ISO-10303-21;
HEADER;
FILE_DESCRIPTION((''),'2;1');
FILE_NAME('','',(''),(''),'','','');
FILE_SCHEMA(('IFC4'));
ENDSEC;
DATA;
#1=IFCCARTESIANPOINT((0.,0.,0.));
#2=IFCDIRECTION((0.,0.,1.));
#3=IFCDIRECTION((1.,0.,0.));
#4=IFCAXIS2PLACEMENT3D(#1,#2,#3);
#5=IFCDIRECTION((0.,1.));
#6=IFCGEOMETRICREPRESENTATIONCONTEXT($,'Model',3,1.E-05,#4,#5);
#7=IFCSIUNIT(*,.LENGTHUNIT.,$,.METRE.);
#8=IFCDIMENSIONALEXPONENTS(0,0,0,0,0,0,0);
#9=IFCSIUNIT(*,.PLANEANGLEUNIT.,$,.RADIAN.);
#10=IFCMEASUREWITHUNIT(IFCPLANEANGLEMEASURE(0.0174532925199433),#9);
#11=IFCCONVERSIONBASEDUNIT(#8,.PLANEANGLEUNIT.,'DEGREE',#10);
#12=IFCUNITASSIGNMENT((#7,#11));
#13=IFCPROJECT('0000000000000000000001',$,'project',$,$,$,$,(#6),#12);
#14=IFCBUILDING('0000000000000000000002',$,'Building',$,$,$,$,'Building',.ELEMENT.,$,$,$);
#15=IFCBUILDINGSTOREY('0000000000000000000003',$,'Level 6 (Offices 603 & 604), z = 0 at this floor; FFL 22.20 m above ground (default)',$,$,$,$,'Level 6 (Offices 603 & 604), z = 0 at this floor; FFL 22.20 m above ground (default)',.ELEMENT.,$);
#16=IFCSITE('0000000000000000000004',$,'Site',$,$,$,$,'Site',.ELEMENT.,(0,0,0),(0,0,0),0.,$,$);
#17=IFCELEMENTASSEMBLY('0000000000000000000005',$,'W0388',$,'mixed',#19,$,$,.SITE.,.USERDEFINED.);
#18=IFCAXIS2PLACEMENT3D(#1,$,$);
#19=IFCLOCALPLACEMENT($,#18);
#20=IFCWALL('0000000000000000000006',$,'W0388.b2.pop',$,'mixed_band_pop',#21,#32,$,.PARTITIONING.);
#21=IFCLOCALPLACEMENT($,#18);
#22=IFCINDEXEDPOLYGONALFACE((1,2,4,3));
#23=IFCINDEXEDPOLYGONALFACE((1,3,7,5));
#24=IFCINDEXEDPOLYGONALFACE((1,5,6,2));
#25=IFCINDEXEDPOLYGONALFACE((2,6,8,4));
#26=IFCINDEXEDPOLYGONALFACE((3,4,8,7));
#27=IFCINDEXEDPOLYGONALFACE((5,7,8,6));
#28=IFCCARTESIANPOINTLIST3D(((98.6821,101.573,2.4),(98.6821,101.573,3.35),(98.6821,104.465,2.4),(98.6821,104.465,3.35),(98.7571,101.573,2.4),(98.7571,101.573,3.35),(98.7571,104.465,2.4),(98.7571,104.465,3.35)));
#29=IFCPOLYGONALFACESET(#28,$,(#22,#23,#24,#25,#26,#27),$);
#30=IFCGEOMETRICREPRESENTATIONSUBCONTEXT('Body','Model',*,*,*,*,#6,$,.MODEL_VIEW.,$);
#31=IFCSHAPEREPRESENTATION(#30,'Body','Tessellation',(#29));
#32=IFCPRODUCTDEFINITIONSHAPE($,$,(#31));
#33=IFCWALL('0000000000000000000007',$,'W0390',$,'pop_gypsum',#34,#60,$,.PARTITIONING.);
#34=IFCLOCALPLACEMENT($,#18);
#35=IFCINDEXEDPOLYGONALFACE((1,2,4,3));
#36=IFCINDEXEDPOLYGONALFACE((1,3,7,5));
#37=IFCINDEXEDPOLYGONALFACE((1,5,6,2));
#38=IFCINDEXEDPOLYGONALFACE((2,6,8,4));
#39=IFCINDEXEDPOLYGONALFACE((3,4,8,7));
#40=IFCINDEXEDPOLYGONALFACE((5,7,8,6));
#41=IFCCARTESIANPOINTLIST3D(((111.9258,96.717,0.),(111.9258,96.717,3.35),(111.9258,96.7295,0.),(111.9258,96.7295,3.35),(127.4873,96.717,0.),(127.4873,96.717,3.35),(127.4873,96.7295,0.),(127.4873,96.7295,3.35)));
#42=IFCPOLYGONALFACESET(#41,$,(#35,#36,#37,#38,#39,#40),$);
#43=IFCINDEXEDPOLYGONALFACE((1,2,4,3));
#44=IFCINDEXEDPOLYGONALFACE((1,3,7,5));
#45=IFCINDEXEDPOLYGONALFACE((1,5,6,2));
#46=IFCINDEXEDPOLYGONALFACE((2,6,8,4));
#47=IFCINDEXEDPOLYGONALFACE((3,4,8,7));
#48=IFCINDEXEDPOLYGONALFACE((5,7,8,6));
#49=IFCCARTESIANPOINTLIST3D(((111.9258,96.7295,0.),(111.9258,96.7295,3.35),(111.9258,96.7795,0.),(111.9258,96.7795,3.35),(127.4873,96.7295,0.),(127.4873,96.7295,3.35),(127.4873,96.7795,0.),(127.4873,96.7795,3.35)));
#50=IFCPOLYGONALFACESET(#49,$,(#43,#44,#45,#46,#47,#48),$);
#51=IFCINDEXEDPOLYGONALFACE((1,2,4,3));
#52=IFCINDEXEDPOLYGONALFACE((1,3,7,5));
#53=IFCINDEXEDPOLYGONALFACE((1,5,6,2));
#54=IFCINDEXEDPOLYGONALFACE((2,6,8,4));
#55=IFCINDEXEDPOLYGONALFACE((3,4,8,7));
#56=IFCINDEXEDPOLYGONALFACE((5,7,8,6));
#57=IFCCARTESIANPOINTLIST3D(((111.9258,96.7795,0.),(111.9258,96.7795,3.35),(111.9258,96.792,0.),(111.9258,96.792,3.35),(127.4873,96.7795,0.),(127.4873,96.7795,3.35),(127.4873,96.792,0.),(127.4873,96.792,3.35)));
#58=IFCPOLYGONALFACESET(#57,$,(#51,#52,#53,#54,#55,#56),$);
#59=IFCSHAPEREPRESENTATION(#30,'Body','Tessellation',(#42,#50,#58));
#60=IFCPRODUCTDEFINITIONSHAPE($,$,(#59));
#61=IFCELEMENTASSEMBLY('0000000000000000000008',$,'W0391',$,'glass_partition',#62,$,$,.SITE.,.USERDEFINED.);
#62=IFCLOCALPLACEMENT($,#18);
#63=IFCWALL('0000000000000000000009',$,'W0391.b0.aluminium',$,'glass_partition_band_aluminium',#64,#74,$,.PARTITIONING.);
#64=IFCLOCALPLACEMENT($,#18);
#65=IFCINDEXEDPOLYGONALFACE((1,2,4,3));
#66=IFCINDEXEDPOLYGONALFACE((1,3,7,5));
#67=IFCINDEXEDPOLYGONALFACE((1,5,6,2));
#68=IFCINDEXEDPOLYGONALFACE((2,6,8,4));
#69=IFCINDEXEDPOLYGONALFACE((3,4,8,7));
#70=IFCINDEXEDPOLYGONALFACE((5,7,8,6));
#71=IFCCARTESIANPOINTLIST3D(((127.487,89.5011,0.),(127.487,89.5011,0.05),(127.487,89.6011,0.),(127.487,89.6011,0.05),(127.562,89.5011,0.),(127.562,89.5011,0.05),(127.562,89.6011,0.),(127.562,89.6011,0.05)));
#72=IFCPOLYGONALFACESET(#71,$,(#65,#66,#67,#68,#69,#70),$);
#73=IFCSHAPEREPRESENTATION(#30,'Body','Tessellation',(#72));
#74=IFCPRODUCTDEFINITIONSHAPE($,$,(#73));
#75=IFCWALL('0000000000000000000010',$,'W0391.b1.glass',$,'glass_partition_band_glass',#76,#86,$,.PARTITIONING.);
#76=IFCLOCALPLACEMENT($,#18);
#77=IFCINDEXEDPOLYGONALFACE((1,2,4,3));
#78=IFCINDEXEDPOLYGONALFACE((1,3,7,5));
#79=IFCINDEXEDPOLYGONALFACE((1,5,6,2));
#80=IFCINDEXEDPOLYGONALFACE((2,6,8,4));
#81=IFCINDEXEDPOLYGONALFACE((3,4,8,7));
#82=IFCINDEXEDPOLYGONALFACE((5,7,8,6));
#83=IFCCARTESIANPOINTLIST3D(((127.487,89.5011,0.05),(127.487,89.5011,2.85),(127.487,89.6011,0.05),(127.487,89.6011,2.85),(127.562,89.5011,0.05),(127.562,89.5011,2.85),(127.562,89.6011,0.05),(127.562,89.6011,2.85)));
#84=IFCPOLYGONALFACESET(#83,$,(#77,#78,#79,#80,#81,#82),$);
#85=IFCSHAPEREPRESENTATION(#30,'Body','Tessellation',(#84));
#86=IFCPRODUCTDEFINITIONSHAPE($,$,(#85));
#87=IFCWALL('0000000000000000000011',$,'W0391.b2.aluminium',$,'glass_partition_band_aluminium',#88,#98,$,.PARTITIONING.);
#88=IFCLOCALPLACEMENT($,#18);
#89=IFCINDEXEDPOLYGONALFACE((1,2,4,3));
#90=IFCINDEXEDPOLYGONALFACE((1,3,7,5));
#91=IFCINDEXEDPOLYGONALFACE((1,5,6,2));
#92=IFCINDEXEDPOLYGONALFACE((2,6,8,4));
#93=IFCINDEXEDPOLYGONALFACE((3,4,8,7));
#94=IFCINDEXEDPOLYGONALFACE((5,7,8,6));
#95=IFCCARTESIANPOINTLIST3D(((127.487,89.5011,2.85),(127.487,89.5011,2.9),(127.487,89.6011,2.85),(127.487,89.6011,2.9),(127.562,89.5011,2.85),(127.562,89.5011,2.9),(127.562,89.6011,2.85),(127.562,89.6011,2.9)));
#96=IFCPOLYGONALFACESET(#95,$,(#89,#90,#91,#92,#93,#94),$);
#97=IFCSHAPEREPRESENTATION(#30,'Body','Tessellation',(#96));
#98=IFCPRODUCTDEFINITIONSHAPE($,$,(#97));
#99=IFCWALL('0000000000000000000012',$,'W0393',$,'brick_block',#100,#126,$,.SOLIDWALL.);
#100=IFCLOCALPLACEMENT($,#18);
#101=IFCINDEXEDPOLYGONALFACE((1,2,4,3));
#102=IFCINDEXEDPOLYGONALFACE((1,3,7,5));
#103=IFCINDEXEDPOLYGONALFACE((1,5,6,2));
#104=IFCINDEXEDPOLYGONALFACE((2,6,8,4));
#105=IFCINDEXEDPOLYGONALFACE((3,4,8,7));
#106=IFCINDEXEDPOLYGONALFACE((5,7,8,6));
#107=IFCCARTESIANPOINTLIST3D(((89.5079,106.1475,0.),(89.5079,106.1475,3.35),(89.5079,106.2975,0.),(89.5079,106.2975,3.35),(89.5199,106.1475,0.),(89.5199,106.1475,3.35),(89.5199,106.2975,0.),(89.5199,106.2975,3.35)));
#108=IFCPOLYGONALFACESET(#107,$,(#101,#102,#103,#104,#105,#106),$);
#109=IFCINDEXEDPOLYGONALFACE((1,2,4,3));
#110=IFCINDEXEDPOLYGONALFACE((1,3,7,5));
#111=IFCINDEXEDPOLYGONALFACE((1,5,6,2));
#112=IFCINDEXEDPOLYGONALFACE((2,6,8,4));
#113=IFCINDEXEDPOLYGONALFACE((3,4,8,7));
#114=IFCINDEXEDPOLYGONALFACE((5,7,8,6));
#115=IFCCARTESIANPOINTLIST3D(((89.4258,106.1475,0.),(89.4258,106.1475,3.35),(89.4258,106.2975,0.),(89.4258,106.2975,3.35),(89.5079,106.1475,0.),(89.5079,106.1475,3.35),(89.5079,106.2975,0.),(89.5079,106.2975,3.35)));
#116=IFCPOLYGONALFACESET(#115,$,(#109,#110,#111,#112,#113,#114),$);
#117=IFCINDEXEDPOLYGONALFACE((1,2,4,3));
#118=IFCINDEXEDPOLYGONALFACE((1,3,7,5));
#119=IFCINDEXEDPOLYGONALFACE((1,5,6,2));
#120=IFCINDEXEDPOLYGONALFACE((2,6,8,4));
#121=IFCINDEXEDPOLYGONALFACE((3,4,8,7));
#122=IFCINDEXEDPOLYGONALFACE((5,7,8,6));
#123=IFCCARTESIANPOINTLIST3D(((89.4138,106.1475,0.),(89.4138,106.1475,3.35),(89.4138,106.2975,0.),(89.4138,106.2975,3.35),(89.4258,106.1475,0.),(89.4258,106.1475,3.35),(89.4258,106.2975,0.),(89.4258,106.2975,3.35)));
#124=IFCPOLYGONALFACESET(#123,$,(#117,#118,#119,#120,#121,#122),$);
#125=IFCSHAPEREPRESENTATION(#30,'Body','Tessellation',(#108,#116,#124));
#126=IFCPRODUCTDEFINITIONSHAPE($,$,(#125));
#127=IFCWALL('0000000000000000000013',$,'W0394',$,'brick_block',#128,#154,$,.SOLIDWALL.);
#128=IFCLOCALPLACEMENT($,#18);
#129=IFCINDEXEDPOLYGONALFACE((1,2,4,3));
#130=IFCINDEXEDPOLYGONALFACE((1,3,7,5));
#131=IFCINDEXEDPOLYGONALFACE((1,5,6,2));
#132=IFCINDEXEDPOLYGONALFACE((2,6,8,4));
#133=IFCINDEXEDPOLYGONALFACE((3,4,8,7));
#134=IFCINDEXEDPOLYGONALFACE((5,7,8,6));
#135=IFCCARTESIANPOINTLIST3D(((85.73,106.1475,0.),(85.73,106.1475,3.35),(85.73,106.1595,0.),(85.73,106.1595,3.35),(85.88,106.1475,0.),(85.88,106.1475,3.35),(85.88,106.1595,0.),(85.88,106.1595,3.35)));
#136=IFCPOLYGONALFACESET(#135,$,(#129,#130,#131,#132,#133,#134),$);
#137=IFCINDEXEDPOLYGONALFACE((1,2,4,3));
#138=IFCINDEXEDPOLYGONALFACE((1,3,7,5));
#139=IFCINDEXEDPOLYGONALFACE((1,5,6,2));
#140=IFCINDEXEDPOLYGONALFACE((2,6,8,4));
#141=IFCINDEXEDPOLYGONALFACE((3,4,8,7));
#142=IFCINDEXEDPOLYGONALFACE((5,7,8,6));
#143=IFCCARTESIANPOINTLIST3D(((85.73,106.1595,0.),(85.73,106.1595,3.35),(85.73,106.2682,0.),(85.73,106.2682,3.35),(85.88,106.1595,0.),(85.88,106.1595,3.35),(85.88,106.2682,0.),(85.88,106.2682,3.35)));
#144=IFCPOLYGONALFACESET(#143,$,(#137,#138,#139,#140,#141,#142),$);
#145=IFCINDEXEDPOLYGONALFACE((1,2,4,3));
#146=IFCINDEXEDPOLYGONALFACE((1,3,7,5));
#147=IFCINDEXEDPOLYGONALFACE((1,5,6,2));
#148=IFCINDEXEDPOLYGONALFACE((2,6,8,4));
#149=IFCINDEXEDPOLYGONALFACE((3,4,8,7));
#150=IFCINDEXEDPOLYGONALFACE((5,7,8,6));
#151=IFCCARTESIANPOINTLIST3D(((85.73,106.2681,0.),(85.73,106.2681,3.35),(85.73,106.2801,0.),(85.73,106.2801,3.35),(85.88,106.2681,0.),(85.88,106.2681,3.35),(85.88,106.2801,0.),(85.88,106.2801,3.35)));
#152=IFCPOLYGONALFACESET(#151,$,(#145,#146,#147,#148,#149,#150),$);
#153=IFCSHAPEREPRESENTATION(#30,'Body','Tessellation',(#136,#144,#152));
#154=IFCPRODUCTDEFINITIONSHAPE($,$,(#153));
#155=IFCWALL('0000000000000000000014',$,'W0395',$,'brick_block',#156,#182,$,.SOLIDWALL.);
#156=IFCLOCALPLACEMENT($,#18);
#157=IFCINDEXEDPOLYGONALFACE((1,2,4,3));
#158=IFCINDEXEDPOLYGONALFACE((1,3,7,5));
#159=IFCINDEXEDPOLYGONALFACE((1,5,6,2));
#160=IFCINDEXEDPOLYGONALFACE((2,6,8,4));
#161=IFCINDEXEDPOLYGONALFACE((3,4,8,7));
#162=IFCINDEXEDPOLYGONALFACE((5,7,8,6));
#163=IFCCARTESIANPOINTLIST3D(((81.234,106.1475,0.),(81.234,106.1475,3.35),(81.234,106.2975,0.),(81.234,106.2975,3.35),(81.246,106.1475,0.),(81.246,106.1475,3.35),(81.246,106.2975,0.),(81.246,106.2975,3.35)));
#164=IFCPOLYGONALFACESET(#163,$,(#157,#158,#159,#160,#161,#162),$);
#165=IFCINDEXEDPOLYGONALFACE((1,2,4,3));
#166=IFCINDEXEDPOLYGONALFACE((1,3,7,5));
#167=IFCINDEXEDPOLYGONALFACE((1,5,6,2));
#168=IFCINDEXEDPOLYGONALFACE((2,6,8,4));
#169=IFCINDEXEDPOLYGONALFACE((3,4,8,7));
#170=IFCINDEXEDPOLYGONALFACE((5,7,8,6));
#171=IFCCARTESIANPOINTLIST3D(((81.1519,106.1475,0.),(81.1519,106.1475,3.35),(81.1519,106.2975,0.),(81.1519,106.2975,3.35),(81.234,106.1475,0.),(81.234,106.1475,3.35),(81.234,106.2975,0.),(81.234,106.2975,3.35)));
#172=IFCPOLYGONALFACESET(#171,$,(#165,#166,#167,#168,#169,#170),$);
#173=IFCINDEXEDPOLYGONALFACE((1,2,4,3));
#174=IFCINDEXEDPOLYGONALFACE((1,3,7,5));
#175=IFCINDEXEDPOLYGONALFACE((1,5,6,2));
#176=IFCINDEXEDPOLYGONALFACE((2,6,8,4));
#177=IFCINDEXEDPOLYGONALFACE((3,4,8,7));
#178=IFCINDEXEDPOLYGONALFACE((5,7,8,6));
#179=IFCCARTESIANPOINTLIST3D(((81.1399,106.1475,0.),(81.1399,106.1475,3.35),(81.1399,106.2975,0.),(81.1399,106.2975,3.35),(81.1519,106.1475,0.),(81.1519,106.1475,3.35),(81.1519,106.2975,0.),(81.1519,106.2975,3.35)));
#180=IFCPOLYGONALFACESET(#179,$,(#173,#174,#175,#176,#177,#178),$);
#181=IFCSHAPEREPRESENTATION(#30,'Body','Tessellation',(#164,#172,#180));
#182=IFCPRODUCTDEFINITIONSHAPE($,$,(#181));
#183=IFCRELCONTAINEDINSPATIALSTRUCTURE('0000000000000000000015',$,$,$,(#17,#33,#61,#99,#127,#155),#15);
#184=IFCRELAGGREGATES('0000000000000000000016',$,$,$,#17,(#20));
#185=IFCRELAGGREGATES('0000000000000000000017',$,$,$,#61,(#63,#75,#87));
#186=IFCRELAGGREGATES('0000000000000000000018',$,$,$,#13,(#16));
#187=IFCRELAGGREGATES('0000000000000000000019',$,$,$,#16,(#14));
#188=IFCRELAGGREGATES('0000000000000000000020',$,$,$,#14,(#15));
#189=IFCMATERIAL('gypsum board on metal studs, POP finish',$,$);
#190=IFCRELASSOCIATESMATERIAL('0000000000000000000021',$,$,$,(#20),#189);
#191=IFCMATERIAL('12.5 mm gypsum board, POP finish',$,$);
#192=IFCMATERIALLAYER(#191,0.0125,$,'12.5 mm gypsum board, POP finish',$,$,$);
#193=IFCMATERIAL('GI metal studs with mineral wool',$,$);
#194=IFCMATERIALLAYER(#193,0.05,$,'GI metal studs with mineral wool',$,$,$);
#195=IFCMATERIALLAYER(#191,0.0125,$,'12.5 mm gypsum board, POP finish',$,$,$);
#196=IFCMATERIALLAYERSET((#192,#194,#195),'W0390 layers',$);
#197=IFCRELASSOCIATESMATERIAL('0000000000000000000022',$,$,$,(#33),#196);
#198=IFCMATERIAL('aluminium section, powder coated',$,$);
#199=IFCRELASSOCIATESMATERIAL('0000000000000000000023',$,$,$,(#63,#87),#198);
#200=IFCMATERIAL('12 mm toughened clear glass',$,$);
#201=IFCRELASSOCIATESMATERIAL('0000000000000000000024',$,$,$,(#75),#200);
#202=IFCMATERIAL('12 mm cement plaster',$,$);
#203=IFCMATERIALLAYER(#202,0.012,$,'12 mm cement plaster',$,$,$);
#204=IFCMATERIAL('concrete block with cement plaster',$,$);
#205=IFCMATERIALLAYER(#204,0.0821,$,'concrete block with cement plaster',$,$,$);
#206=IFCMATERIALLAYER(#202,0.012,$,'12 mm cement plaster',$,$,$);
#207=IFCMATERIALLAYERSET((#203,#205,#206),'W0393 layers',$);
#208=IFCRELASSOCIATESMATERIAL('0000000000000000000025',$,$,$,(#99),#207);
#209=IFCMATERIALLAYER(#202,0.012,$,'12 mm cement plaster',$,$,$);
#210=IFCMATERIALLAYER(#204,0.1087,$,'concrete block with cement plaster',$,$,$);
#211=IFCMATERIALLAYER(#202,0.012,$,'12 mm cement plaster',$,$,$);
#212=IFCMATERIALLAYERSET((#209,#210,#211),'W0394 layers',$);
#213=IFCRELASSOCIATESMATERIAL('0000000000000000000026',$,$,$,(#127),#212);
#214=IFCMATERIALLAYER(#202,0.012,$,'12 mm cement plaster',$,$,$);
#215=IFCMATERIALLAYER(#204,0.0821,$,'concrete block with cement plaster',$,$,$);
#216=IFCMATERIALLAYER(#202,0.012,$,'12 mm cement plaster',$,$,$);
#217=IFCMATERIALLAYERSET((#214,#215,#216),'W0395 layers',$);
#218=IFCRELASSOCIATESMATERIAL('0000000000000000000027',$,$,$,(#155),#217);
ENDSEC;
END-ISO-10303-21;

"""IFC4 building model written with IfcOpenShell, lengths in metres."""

from ifc_helpers import new_model, entity, si_unit, converted_unit, direction, frame, frame_2d, origin_with_axes, place, context, subcontext, project, spatial, rectangle, extrude, material, layer, layer_set, layer_usage, element, aggregate, save


model = new_model("IFC4")

# Units and contexts
model_context = context("Model", 3, precision=1e-05, world=origin_with_axes(), true_north=direction((0.0, 1.0)))
body_context = subcontext(model_context, "Body", "Model", "MODEL_VIEW")
ifc_project = project(units=[si_unit("LENGTHUNIT", "METRE"), converted_unit("PLANEANGLEUNIT", "DEGREE", entity("IfcPlaneAngleMeasure", 0.0174532925199433), si_unit("PLANEANGLEUNIT", "RADIAN"), dimensions=[0, 0, 0, 0, 0, 0, 0])], contexts=[model_context])

# Site, building, storey
site = spatial("IfcSite", under=ifc_project, Name="Site", LongName="Site", CompositionType="ELEMENT", RefLatitude=(0, 0, 0), RefLongitude=(0, 0, 0), RefElevation=0.0)
building = spatial("IfcBuilding", under=site, Name="Building", LongName="Building", CompositionType="ELEMENT")
storey = spatial("IfcBuildingStorey", under=building, Name="Level 6 (Offices 603 & 604), z = 0 at this floor; FFL 22.20 m above ground (default)", LongName="Level 6 (Offices 603 & 604), z = 0 at this floor; FFL 22.20 m above ground (default)", CompositionType="ELEMENT")

# Element assembly, wall
assembly_1 = element("IfcElementAssembly", 1, inside=storey, Name="W0388", ObjectType="mixed", AssemblyPlace="SITE", PredefinedType="USERDEFINED")
ifc_material_1 = material(Name="gypsum board on metal studs, POP finish")
placement = place(None, origin_with_axes())
wall_1 = element("IfcWall", 2, at=placement, material=ifc_material_1, Name="W0388.b2.pop", ObjectType="mixed_band_pop", PredefinedType="PARTITIONING", context=body_context, shape_type="SweptSolid", body=[
    extrude(rectangle(XDim=2.892, YDim=0.075, at=frame_2d((0.0, 0.0), x_axis=(0.0, 1.0))), frame((98.7196, 103.019, 2.4), z_axis=(0.0, 0.0, 1.0), x_axis=(1.0, 0.0, 0.0)), (0.0, 0.0, 1.0), 0.95),
])
aggregate(assembly_1, [wall_1])

# Wall
ifc_material_2 = material(Name="12.5 mm gypsum board, POP finish")
ifc_layer_1 = layer(ifc_material_2, 0.0125, Name="12.5 mm gypsum board, POP finish")
ifc_material_3 = material(Name="GI metal studs with mineral wool")
ifc_layer_2 = layer(ifc_material_3, 0.05, Name="GI metal studs with mineral wool")
ifc_layer_3 = layer(ifc_material_2, 0.0125, Name="12.5 mm gypsum board, POP finish")
ifc_layer_set_1 = layer_set([ifc_layer_1, ifc_layer_2, ifc_layer_3], Name="W0390 layers")
ifc_layer_usage_1 = layer_usage(ifc_layer_set_1, "AXIS2", "POSITIVE", -0.0375)
element("IfcWall", 3, at=placement, inside=storey, material=ifc_layer_usage_1, Name="W0390", ObjectType="pop_gypsum", PredefinedType="PARTITIONING", context=body_context, shape_type="SweptSolid", body=[
    extrude(rectangle(XDim=15.5615, YDim=0.0125, at=frame_2d((0.0, 0.0), x_axis=(1.0, 0.0))), frame((119.7065, 96.7232, 0.0), z_axis=(0.0, 0.0, 1.0), x_axis=(1.0, 0.0, 0.0)), (0.0, 0.0, 1.0), 3.35),
    extrude(rectangle(XDim=15.5615, YDim=0.05, at=frame_2d((0.0, 0.0312), x_axis=(1.0, 0.0))), frame((119.7065, 96.7232, 0.0), z_axis=(0.0, 0.0, 1.0), x_axis=(1.0, 0.0, 0.0)), (0.0, 0.0, 1.0), 3.35),
    extrude(rectangle(XDim=15.5615, YDim=0.0125, at=frame_2d((0.0, 0.0625), x_axis=(1.0, 0.0))), frame((119.7065, 96.7232, 0.0), z_axis=(0.0, 0.0, 1.0), x_axis=(1.0, 0.0, 0.0)), (0.0, 0.0, 1.0), 3.35),
])

# Element assembly, walls
assembly_2 = element("IfcElementAssembly", 4, inside=storey, Name="W0391", ObjectType="glass_partition", AssemblyPlace="SITE", PredefinedType="USERDEFINED")
ifc_material_4 = material(Name="aluminium section, powder coated")
wall_2 = element("IfcWall", 5, at=placement, material=ifc_material_4, Name="W0391.b0.aluminium", ObjectType="glass_partition_band_aluminium", PredefinedType="PARTITIONING", context=body_context, shape_type="SweptSolid", body=[
    extrude(rectangle(XDim=0.1, YDim=0.075, at=frame_2d((0.0, 0.0), x_axis=(0.0, 1.0))), frame((127.5245, 89.5511, 0.0), z_axis=(0.0, 0.0, 1.0), x_axis=(1.0, 0.0, 0.0)), (0.0, 0.0, 1.0), 0.05),
])
ifc_material_5 = material(Name="12 mm toughened clear glass")
wall_3 = element("IfcWall", 6, at=placement, material=ifc_material_5, Name="W0391.b1.glass", ObjectType="glass_partition_band_glass", PredefinedType="PARTITIONING", context=body_context, shape_type="SweptSolid", body=[
    extrude(rectangle(XDim=0.1, YDim=0.075, at=frame_2d((0.0, 0.0), x_axis=(0.0, 1.0))), frame((127.5245, 89.5511, 0.05), z_axis=(0.0, 0.0, 1.0), x_axis=(1.0, 0.0, 0.0)), (0.0, 0.0, 1.0), 2.8),
])
wall_4 = element("IfcWall", 7, at=placement, material=ifc_material_4, Name="W0391.b2.aluminium", ObjectType="glass_partition_band_aluminium", PredefinedType="PARTITIONING", context=body_context, shape_type="SweptSolid", body=[
    extrude(rectangle(XDim=0.1, YDim=0.075, at=frame_2d((0.0, 0.0), x_axis=(0.0, 1.0))), frame((127.5245, 89.5511, 2.85), z_axis=(0.0, 0.0, 1.0), x_axis=(1.0, 0.0, 0.0)), (0.0, 0.0, 1.0), 0.05),
])
aggregate(assembly_2, [wall_2, wall_3, wall_4])

# Walls
ifc_material_6 = material(Name="12 mm cement plaster")
ifc_layer_4 = layer(ifc_material_6, 0.012, Name="12 mm cement plaster")
ifc_material_7 = material(Name="concrete block with cement plaster")
ifc_layer_5 = layer(ifc_material_7, 0.0821, Name="concrete block with cement plaster")
ifc_layer_6 = layer(ifc_material_6, 0.012, Name="12 mm cement plaster")
ifc_layer_set_2 = layer_set([ifc_layer_4, ifc_layer_5, ifc_layer_6], Name="W0393 layers")
ifc_layer_usage_2 = layer_usage(ifc_layer_set_2, "AXIS2", "POSITIVE", -0.053)
element("IfcWall", 8, at=placement, inside=storey, material=ifc_layer_usage_2, Name="W0393", ObjectType="brick_block", PredefinedType="SOLIDWALL", context=body_context, shape_type="SweptSolid", body=[
    extrude(rectangle(XDim=0.15, YDim=0.012, at=frame_2d((0.0, 0.0), x_axis=(0.0, 1.0))), frame((89.5139, 106.2225, 0.0), z_axis=(0.0, 0.0, 1.0), x_axis=(1.0, 0.0, 0.0)), (0.0, 0.0, 1.0), 3.35),
    extrude(rectangle(XDim=0.15, YDim=0.0821, at=frame_2d((-0.0471, 0.0), x_axis=(0.0, 1.0))), frame((89.5139, 106.2225, 0.0), z_axis=(0.0, 0.0, 1.0), x_axis=(1.0, 0.0, 0.0)), (0.0, 0.0, 1.0), 3.35),
    extrude(rectangle(XDim=0.15, YDim=0.012, at=frame_2d((-0.0941, 0.0), x_axis=(0.0, 1.0))), frame((89.5139, 106.2225, 0.0), z_axis=(0.0, 0.0, 1.0), x_axis=(1.0, 0.0, 0.0)), (0.0, 0.0, 1.0), 3.35),
])
ifc_layer_7 = layer(ifc_material_6, 0.012, Name="12 mm cement plaster")
ifc_layer_8 = layer(ifc_material_7, 0.1087, Name="concrete block with cement plaster")
ifc_layer_9 = layer(ifc_material_6, 0.012, Name="12 mm cement plaster")
ifc_layer_set_3 = layer_set([ifc_layer_7, ifc_layer_8, ifc_layer_9], Name="W0394 layers")
ifc_layer_usage_3 = layer_usage(ifc_layer_set_3, "AXIS2", "POSITIVE", -0.0664)
element("IfcWall", 9, at=placement, inside=storey, material=ifc_layer_usage_3, Name="W0394", ObjectType="brick_block", PredefinedType="SOLIDWALL", context=body_context, shape_type="SweptSolid", body=[
    extrude(rectangle(XDim=0.15, YDim=0.012, at=frame_2d((0.0, 0.0), x_axis=(1.0, 0.0))), frame((85.805, 106.1535, 0.0), z_axis=(0.0, 0.0, 1.0), x_axis=(1.0, 0.0, 0.0)), (0.0, 0.0, 1.0), 3.35),
    extrude(rectangle(XDim=0.15, YDim=0.1087, at=frame_2d((0.0, 0.0604), x_axis=(1.0, 0.0))), frame((85.805, 106.1535, 0.0), z_axis=(0.0, 0.0, 1.0), x_axis=(1.0, 0.0, 0.0)), (0.0, 0.0, 1.0), 3.35),
    extrude(rectangle(XDim=0.15, YDim=0.012, at=frame_2d((0.0, 0.1207), x_axis=(1.0, 0.0))), frame((85.805, 106.1535, 0.0), z_axis=(0.0, 0.0, 1.0), x_axis=(1.0, 0.0, 0.0)), (0.0, 0.0, 1.0), 3.35),
])
ifc_layer_10 = layer(ifc_material_6, 0.012, Name="12 mm cement plaster")
ifc_layer_11 = layer(ifc_material_7, 0.0821, Name="concrete block with cement plaster")
ifc_layer_12 = layer(ifc_material_6, 0.012, Name="12 mm cement plaster")
ifc_layer_set_4 = layer_set([ifc_layer_10, ifc_layer_11, ifc_layer_12], Name="W0395 layers")
ifc_layer_usage_4 = layer_usage(ifc_layer_set_4, "AXIS2", "POSITIVE", -0.053)
element("IfcWall", 10, at=placement, inside=storey, material=ifc_layer_usage_4, Name="W0395", ObjectType="brick_block", PredefinedType="SOLIDWALL", context=body_context, shape_type="SweptSolid", body=[
    extrude(rectangle(XDim=0.15, YDim=0.012, at=frame_2d((0.0, 0.0), x_axis=(0.0, 1.0))), frame((81.24, 106.2225, 0.0), z_axis=(0.0, 0.0, 1.0), x_axis=(1.0, 0.0, 0.0)), (0.0, 0.0, 1.0), 3.35),
    extrude(rectangle(XDim=0.15, YDim=0.0821, at=frame_2d((-0.0471, 0.0), x_axis=(0.0, 1.0))), frame((81.24, 106.2225, 0.0), z_axis=(0.0, 0.0, 1.0), x_axis=(1.0, 0.0, 0.0)), (0.0, 0.0, 1.0), 3.35),
    extrude(rectangle(XDim=0.15, YDim=0.012, at=frame_2d((-0.0941, 0.0), x_axis=(0.0, 1.0))), frame((81.24, 106.2225, 0.0), z_axis=(0.0, 0.0, 1.0), x_axis=(1.0, 0.0, 0.0)), (0.0, 0.0, 1.0), 3.35),
])

save(model, "model.ifc")
